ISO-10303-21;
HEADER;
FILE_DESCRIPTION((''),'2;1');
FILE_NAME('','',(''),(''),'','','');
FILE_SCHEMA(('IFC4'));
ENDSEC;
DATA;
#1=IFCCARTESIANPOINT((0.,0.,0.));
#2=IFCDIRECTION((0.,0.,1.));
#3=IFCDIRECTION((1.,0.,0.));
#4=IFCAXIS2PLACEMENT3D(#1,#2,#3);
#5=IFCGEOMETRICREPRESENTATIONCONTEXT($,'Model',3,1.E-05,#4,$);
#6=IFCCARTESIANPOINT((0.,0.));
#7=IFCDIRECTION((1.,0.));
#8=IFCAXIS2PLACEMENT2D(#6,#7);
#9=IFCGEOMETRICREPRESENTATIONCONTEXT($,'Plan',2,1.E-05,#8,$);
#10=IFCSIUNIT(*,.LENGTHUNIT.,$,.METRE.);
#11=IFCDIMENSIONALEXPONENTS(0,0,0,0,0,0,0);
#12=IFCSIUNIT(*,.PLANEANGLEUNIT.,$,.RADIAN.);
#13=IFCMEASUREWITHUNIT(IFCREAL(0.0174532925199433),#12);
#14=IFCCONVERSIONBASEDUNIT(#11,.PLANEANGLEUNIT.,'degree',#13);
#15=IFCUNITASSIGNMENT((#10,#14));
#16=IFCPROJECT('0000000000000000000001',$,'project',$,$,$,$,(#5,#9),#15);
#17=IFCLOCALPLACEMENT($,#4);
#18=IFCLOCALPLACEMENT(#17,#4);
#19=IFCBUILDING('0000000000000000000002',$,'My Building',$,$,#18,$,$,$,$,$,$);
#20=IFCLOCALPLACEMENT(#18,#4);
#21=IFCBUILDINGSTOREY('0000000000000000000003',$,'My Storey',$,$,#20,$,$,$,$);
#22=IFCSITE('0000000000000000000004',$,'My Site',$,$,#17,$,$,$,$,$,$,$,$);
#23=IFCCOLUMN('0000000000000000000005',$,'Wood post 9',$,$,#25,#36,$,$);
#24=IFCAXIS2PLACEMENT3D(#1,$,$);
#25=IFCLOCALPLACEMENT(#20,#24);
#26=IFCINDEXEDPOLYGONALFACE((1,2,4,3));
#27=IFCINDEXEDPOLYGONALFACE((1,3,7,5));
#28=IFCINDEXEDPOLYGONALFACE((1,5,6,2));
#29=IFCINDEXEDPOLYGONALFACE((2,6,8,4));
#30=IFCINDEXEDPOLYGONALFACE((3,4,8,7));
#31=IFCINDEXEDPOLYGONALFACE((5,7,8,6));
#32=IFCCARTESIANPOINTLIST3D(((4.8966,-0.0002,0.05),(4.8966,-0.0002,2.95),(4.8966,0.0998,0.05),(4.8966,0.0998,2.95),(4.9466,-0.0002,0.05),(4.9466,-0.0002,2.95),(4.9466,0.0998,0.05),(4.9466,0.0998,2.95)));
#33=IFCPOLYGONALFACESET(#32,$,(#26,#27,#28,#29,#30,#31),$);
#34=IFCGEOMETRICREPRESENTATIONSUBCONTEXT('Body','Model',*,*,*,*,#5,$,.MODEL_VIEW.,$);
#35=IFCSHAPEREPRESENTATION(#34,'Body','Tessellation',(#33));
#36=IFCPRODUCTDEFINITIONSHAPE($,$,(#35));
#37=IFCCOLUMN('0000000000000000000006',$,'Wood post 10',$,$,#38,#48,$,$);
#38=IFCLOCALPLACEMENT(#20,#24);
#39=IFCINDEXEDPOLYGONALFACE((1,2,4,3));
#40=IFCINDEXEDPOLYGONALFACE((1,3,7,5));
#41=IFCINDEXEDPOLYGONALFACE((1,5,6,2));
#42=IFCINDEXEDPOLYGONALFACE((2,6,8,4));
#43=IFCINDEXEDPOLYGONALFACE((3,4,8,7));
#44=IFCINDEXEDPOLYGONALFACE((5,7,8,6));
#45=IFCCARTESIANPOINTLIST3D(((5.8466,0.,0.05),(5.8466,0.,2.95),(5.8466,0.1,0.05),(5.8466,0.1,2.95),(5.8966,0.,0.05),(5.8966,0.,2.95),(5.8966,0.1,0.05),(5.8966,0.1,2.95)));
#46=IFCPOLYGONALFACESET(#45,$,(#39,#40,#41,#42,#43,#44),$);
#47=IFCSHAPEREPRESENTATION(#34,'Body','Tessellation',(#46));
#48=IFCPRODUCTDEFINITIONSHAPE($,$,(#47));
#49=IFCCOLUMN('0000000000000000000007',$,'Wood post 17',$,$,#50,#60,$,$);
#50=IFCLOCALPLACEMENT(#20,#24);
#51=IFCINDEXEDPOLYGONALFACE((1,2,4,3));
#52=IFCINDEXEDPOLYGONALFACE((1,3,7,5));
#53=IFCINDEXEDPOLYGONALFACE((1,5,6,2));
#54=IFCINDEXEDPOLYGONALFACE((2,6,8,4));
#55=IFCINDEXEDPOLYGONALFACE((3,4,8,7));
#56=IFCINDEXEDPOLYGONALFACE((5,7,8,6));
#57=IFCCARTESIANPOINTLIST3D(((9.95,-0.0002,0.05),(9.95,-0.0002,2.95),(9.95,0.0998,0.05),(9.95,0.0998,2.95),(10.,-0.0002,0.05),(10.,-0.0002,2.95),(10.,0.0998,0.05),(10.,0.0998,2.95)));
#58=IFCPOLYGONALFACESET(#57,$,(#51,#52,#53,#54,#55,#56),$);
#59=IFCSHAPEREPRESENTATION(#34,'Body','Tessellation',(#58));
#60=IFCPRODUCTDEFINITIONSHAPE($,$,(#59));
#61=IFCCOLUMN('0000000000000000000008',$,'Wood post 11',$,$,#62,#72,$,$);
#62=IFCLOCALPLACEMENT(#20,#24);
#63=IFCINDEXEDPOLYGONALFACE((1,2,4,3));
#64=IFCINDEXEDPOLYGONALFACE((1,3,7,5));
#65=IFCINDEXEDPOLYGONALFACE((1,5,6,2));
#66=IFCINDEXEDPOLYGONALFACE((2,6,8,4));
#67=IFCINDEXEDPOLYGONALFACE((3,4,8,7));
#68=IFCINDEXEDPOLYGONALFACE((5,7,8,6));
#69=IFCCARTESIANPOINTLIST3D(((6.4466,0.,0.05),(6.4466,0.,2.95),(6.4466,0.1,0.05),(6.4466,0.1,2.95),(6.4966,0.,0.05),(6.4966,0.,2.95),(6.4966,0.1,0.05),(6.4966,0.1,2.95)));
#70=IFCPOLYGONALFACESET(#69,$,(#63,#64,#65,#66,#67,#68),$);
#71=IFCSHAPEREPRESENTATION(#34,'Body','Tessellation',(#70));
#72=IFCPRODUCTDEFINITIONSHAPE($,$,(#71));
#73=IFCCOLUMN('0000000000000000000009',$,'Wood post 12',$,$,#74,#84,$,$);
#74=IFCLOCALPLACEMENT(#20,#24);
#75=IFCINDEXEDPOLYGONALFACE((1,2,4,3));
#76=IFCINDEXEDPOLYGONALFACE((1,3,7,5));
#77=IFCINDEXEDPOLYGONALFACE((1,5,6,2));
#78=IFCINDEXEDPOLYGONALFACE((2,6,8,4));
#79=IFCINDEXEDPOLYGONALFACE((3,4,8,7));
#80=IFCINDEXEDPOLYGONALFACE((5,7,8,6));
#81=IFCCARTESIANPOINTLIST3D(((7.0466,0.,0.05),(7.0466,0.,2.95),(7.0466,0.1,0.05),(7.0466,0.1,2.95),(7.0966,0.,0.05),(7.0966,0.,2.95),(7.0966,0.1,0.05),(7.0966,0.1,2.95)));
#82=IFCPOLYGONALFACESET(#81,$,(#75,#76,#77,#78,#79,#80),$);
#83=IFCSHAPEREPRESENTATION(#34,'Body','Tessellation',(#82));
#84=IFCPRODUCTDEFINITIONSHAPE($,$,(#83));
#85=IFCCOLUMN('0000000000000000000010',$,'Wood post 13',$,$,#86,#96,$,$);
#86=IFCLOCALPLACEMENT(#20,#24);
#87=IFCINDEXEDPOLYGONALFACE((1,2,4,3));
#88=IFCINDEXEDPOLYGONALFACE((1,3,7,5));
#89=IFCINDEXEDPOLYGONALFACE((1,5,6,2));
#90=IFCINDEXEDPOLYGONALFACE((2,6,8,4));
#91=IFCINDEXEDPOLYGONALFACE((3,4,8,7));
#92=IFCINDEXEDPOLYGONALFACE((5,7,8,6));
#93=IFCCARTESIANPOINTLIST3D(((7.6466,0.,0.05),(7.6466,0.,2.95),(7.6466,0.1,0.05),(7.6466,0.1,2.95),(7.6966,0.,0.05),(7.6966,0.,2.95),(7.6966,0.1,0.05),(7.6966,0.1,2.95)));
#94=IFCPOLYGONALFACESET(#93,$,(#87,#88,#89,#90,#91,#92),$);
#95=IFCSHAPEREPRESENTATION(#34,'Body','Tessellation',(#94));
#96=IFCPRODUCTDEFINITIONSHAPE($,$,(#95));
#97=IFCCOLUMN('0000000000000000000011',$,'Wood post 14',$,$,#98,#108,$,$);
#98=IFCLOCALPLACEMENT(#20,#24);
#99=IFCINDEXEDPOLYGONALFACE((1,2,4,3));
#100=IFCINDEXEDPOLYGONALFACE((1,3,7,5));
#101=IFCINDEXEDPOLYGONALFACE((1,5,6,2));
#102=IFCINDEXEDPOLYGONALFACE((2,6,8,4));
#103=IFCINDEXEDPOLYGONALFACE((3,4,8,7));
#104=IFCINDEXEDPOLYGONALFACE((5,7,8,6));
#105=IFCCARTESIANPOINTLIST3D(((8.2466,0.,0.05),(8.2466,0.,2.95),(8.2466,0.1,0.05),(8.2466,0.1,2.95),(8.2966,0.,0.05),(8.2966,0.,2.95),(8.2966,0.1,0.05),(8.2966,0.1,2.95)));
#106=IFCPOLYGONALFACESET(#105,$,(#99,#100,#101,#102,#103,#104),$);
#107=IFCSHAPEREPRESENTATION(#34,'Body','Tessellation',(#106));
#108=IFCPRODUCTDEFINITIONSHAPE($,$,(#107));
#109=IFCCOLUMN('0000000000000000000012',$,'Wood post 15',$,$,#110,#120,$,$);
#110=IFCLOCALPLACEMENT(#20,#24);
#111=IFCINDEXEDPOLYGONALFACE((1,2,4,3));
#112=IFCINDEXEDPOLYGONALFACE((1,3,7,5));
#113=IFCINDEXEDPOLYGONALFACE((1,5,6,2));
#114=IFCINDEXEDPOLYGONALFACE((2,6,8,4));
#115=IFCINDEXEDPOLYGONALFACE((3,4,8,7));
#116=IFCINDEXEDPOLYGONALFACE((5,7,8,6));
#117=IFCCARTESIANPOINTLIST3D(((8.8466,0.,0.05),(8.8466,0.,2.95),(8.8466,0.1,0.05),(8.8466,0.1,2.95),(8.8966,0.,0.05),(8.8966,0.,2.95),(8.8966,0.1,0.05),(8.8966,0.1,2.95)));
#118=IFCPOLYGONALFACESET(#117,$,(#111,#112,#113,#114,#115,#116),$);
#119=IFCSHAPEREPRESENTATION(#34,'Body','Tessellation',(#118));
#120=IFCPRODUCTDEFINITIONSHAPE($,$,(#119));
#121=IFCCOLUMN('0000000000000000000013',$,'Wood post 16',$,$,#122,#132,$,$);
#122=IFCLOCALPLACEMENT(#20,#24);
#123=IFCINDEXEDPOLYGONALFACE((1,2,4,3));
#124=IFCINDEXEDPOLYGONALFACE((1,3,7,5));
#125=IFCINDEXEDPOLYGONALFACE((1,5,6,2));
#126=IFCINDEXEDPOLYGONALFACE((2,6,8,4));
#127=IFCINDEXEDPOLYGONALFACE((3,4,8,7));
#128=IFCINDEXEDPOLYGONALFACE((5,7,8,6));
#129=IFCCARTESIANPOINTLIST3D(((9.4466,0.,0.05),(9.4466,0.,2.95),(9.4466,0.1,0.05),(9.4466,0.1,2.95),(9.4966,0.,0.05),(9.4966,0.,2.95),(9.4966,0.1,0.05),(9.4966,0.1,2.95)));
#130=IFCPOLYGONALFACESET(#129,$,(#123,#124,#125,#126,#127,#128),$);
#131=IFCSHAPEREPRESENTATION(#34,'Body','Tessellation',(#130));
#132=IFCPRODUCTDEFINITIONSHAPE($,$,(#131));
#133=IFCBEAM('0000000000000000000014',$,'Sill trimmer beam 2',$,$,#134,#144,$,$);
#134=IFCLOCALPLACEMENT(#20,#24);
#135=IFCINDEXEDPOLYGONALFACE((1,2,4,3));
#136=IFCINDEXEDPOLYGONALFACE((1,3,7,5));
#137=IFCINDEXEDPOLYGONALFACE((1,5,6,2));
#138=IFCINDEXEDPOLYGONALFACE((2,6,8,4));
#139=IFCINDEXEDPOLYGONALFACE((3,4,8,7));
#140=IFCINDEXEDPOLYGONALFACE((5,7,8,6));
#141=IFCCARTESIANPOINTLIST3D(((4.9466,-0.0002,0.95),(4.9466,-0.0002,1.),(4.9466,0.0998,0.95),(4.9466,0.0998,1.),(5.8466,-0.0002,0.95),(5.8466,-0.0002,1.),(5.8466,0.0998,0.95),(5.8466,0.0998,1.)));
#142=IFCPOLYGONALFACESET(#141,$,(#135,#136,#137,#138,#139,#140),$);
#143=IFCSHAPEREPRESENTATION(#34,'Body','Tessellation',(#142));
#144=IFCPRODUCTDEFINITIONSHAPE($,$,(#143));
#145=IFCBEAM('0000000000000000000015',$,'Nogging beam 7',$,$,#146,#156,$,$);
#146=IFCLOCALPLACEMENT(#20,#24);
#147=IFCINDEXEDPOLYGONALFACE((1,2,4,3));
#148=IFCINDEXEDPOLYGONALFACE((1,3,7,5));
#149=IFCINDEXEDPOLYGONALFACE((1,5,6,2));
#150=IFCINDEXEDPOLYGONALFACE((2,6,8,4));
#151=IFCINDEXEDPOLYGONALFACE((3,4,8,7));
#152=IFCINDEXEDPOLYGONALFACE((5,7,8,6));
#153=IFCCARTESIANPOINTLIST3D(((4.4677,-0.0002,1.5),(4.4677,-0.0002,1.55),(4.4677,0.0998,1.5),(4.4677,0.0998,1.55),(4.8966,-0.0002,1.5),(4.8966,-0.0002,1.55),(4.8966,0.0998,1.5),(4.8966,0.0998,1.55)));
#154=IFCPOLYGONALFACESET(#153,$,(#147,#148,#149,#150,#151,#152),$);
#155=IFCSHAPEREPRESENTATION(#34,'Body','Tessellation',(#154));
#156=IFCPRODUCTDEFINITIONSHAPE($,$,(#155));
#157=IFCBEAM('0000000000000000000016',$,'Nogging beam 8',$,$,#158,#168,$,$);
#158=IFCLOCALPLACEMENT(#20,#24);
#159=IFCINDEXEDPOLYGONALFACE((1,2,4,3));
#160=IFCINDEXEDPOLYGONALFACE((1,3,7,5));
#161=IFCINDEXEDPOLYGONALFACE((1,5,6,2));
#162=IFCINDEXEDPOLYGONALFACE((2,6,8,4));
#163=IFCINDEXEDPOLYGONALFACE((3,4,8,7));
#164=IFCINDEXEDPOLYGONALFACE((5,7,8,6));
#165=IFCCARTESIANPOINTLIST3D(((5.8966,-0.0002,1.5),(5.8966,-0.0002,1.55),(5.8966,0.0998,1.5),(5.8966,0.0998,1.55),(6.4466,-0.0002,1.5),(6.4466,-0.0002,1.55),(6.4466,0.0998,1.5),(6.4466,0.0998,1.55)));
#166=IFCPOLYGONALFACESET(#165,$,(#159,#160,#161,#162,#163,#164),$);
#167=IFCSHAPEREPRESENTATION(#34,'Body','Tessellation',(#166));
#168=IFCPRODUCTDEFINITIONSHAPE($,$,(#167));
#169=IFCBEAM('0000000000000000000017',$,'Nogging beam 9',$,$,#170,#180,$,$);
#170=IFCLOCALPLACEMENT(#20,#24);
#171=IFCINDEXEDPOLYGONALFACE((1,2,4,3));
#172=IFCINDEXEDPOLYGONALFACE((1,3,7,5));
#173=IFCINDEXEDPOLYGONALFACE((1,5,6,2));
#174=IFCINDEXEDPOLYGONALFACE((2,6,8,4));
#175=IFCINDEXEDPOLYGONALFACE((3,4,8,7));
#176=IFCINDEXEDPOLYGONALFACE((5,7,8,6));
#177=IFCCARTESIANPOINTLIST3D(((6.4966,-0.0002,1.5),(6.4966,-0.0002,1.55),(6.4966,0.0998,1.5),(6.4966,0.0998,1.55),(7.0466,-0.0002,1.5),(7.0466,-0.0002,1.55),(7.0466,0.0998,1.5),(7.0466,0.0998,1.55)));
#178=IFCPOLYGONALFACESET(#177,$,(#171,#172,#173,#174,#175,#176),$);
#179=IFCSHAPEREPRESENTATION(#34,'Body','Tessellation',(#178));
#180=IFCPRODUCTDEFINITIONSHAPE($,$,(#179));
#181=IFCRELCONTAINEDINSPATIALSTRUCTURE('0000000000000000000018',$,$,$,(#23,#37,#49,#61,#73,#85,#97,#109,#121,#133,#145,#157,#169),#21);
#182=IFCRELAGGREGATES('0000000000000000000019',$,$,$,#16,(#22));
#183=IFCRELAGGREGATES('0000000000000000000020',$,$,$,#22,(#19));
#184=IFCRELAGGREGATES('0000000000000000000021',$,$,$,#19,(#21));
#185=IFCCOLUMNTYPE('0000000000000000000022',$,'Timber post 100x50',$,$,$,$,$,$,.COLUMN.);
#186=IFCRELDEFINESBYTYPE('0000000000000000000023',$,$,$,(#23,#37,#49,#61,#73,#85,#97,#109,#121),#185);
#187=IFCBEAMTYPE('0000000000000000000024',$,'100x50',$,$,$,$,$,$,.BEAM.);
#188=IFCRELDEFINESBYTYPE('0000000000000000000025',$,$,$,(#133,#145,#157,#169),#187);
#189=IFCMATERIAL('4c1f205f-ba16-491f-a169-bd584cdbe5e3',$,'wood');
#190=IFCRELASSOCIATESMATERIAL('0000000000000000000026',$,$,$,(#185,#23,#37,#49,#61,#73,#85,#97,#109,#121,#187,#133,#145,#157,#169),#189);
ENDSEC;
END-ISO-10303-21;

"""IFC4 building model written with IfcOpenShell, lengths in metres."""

from ifc_helpers import new_model, entity, si_unit, converted_unit, frame, origin_with_axes, origin_2d_with_axis, place, context, subcontext, project, spatial, indexed_curve, outline, extrude, material, material_profile, profile_set, profile_usage, type_object, element, save


model = new_model("IFC4")

# Units and contexts
model_context = context("Model", 3, precision=1e-05, world=origin_with_axes())
plan_context = context("Plan", 2, precision=1e-05, world=origin_2d_with_axis())
body_context = subcontext(model_context, "Body", "Model", "MODEL_VIEW")
ifc_project = project(units=[si_unit("LENGTHUNIT", "METRE"), converted_unit("PLANEANGLEUNIT", "degree", entity("IfcReal", 0.0174532925199433), si_unit("PLANEANGLEUNIT", "RADIAN"), dimensions=[0, 0, 0, 0, 0, 0, 0])], contexts=[model_context, plan_context])

# Site, building, storey
site_placement = place(None, origin_with_axes())
site = spatial("IfcSite", under=ifc_project, at=site_placement, Name="My Site")
building_placement = place(site_placement, origin_with_axes())
building = spatial("IfcBuilding", under=site, at=building_placement, Name="My Building")
storey_placement = place(building_placement, origin_with_axes())
storey = spatial("IfcBuildingStorey", under=building, at=storey_placement, Name="My Storey")

# Columns
ifc_material_1 = material(Name="4c1f205f-ba16-491f-a169-bd584cdbe5e3", Category="wood")
ifc_material_profile_1 = material_profile(ifc_material_1, outline(indexed_curve([(-0.05, 0.025), (0.05, 0.025), (0.05, -0.025), (-0.05, -0.025), (-0.05, 0.025)])))
ifc_profile_set_1 = profile_set([ifc_material_profile_1])
ifc_profile_usage_1 = profile_usage(ifc_profile_set_1, cardinal=5)
column_type = type_object("IfcColumnType", Name="Timber post 100x50", PredefinedType="COLUMN", material=ifc_profile_set_1)
column_1_placement = place(storey_placement, frame((4.9216, 0.0498, 0.05), z_axis=(0.0, 0.0, 1.0), x_axis=(0.0, 1.0, 0.0)))
element("IfcColumn", 1, at=column_1_placement, inside=storey, type_object=column_type, material=ifc_profile_usage_1, Name="Wood post 9", context=body_context, shape_type="SweptSolid", body=[
    extrude(outline(indexed_curve([(-0.05, 0.025), (0.05, 0.025), (0.05, -0.025), (-0.05, -0.025), (-0.05, 0.025)])), origin_with_axes(), (0.0, 0.0, 1.0), 2.9),
])
ifc_profile_usage_2 = profile_usage(ifc_profile_set_1, cardinal=5)
column_2_placement = place(storey_placement, frame((5.8716, 0.05, 0.05), z_axis=(0.0, 0.0, 1.0), x_axis=(0.0, 1.0, 0.0)))
element("IfcColumn", 2, at=column_2_placement, inside=storey, type_object=column_type, material=ifc_profile_usage_2, Name="Wood post 10", context=body_context, shape_type="SweptSolid", body=[
    extrude(outline(indexed_curve([(-0.05, 0.025), (0.05, 0.025), (0.05, -0.025), (-0.05, -0.025), (-0.05, 0.025)])), origin_with_axes(), (0.0, 0.0, 1.0), 2.9),
])
ifc_profile_usage_3 = profile_usage(ifc_profile_set_1, cardinal=5)
column_3_placement = place(storey_placement, frame((9.975, 0.0498, 0.05), z_axis=(0.0, 0.0, 1.0), x_axis=(0.0, 1.0, 0.0)))
element("IfcColumn", 3, at=column_3_placement, inside=storey, type_object=column_type, material=ifc_profile_usage_3, Name="Wood post 17", context=body_context, shape_type="SweptSolid", body=[
    extrude(outline(indexed_curve([(-0.05, 0.025), (0.05, 0.025), (0.05, -0.025), (-0.05, -0.025), (-0.05, 0.025)])), origin_with_axes(), (0.0, 0.0, 1.0), 2.9),
])
ifc_profile_usage_4 = profile_usage(ifc_profile_set_1, cardinal=5)
column_4_placement = place(storey_placement, frame((6.4716, 0.05, 0.05), z_axis=(0.0, 0.0, 1.0), x_axis=(0.0, 1.0, 0.0)))
element("IfcColumn", 4, at=column_4_placement, inside=storey, type_object=column_type, material=ifc_profile_usage_4, Name="Wood post 11", context=body_context, shape_type="SweptSolid", body=[
    extrude(outline(indexed_curve([(-0.05, 0.025), (0.05, 0.025), (0.05, -0.025), (-0.05, -0.025), (-0.05, 0.025)])), origin_with_axes(), (0.0, 0.0, 1.0), 2.9),
])
ifc_profile_usage_5 = profile_usage(ifc_profile_set_1, cardinal=5)
column_5_placement = place(storey_placement, frame((7.0716, 0.05, 0.05), z_axis=(0.0, 0.0, 1.0), x_axis=(0.0, 1.0, 0.0)))
element("IfcColumn", 5, at=column_5_placement, inside=storey, type_object=column_type, material=ifc_profile_usage_5, Name="Wood post 12", context=body_context, shape_type="SweptSolid", body=[
    extrude(outline(indexed_curve([(-0.05, 0.025), (0.05, 0.025), (0.05, -0.025), (-0.05, -0.025), (-0.05, 0.025)])), origin_with_axes(), (0.0, 0.0, 1.0), 2.9),
])
ifc_profile_usage_6 = profile_usage(ifc_profile_set_1, cardinal=5)
column_6_placement = place(storey_placement, frame((7.6716, 0.05, 0.05), z_axis=(0.0, 0.0, 1.0), x_axis=(0.0, 1.0, 0.0)))
element("IfcColumn", 6, at=column_6_placement, inside=storey, type_object=column_type, material=ifc_profile_usage_6, Name="Wood post 13", context=body_context, shape_type="SweptSolid", body=[
    extrude(outline(indexed_curve([(-0.05, 0.025), (0.05, 0.025), (0.05, -0.025), (-0.05, -0.025), (-0.05, 0.025)])), origin_with_axes(), (0.0, 0.0, 1.0), 2.9),
])
ifc_profile_usage_7 = profile_usage(ifc_profile_set_1, cardinal=5)
column_7_placement = place(storey_placement, frame((8.2716, 0.05, 0.05), z_axis=(0.0, 0.0, 1.0), x_axis=(0.0, 1.0, 0.0)))
element("IfcColumn", 7, at=column_7_placement, inside=storey, type_object=column_type, material=ifc_profile_usage_7, Name="Wood post 14", context=body_context, shape_type="SweptSolid", body=[
    extrude(outline(indexed_curve([(-0.05, 0.025), (0.05, 0.025), (0.05, -0.025), (-0.05, -0.025), (-0.05, 0.025)])), origin_with_axes(), (0.0, 0.0, 1.0), 2.9),
])
ifc_profile_usage_8 = profile_usage(ifc_profile_set_1, cardinal=5)
column_8_placement = place(storey_placement, frame((8.8716, 0.05, 0.05), z_axis=(0.0, 0.0, 1.0), x_axis=(0.0, 1.0, 0.0)))
element("IfcColumn", 8, at=column_8_placement, inside=storey, type_object=column_type, material=ifc_profile_usage_8, Name="Wood post 15", context=body_context, shape_type="SweptSolid", body=[
    extrude(outline(indexed_curve([(-0.05, 0.025), (0.05, 0.025), (0.05, -0.025), (-0.05, -0.025), (-0.05, 0.025)])), origin_with_axes(), (0.0, 0.0, 1.0), 2.9),
])
ifc_profile_usage_9 = profile_usage(ifc_profile_set_1, cardinal=5)
column_9_placement = place(storey_placement, frame((9.4716, 0.05, 0.05), z_axis=(0.0, 0.0, 1.0), x_axis=(0.0, 1.0, 0.0)))
element("IfcColumn", 9, at=column_9_placement, inside=storey, type_object=column_type, material=ifc_profile_usage_9, Name="Wood post 16", context=body_context, shape_type="SweptSolid", body=[
    extrude(outline(indexed_curve([(-0.05, 0.025), (0.05, 0.025), (0.05, -0.025), (-0.05, -0.025), (-0.05, 0.025)])), origin_with_axes(), (0.0, 0.0, 1.0), 2.9),
])

# Beams
ifc_material_profile_2 = material_profile(ifc_material_1, outline(indexed_curve([(-0.05, 0.025), (0.05, 0.025), (0.05, -0.025), (-0.05, -0.025), (-0.05, 0.025)])))
ifc_profile_set_2 = profile_set([ifc_material_profile_2])
ifc_profile_usage_10 = profile_usage(ifc_profile_set_2, cardinal=5)
beam_type_1 = type_object("IfcBeamType", Name="100x50", PredefinedType="BEAM", material=ifc_profile_set_2)
beam_1_placement = place(storey_placement, frame((4.9466, 0.0498, 0.975), z_axis=(1.0, -0.000001, 0.000001), x_axis=(0.000001, 1.0, 0.0)))
element("IfcBeam", 10, at=beam_1_placement, inside=storey, type_object=beam_type_1, material=ifc_profile_usage_10, Name="Sill trimmer beam 2", context=body_context, shape_type="SweptSolid", body=[
    extrude(outline(indexed_curve([(-0.05, 0.025), (0.05, 0.025), (0.05, -0.025), (-0.05, -0.025), (-0.05, 0.025)])), origin_with_axes(), (0.0, 0.0, 1.0), 0.9),
])
ifc_profile_usage_11 = profile_usage(ifc_profile_set_2, cardinal=5)
beam_2_placement = place(storey_placement, frame((4.4677, 0.0498, 1.525), z_axis=(1.0, -0.000001, 0.000001), x_axis=(0.000001, 1.0, 0.0)))
element("IfcBeam", 11, at=beam_2_placement, inside=storey, type_object=beam_type_1, material=ifc_profile_usage_11, Name="Nogging beam 7", context=body_context, shape_type="SweptSolid", body=[
    extrude(outline(indexed_curve([(-0.05, 0.025), (0.05, 0.025), (0.05, -0.025), (-0.05, -0.025), (-0.05, 0.025)])), origin_with_axes(), (0.0, 0.0, 1.0), 0.4289),
])
ifc_profile_usage_12 = profile_usage(ifc_profile_set_2, cardinal=5)
beam_3_placement = place(storey_placement, frame((5.8966, 0.0498, 1.525), z_axis=(1.0, -0.000001, 0.000001), x_axis=(0.000001, 1.0, 0.0)))
element("IfcBeam", 12, at=beam_3_placement, inside=storey, type_object=beam_type_1, material=ifc_profile_usage_12, Name="Nogging beam 8", context=body_context, shape_type="SweptSolid", body=[
    extrude(outline(indexed_curve([(-0.05, 0.025), (0.05, 0.025), (0.05, -0.025), (-0.05, -0.025), (-0.05, 0.025)])), origin_with_axes(), (0.0, 0.0, 1.0), 0.55),
])
ifc_profile_usage_13 = profile_usage(ifc_profile_set_2, cardinal=5)
beam_4_placement = place(storey_placement, frame((6.4966, 0.0498, 1.525), z_axis=(1.0, -0.000001, 0.000001), x_axis=(0.000001, 1.0, 0.0)))
element("IfcBeam", 13, at=beam_4_placement, inside=storey, type_object=beam_type_1, material=ifc_profile_usage_13, Name="Nogging beam 9", context=body_context, shape_type="SweptSolid", body=[
    extrude(outline(indexed_curve([(-0.05, 0.025), (0.05, 0.025), (0.05, -0.025), (-0.05, -0.025), (-0.05, 0.025)])), origin_with_axes(), (0.0, 0.0, 1.0), 0.55),
])

save(model, "model.ifc")
